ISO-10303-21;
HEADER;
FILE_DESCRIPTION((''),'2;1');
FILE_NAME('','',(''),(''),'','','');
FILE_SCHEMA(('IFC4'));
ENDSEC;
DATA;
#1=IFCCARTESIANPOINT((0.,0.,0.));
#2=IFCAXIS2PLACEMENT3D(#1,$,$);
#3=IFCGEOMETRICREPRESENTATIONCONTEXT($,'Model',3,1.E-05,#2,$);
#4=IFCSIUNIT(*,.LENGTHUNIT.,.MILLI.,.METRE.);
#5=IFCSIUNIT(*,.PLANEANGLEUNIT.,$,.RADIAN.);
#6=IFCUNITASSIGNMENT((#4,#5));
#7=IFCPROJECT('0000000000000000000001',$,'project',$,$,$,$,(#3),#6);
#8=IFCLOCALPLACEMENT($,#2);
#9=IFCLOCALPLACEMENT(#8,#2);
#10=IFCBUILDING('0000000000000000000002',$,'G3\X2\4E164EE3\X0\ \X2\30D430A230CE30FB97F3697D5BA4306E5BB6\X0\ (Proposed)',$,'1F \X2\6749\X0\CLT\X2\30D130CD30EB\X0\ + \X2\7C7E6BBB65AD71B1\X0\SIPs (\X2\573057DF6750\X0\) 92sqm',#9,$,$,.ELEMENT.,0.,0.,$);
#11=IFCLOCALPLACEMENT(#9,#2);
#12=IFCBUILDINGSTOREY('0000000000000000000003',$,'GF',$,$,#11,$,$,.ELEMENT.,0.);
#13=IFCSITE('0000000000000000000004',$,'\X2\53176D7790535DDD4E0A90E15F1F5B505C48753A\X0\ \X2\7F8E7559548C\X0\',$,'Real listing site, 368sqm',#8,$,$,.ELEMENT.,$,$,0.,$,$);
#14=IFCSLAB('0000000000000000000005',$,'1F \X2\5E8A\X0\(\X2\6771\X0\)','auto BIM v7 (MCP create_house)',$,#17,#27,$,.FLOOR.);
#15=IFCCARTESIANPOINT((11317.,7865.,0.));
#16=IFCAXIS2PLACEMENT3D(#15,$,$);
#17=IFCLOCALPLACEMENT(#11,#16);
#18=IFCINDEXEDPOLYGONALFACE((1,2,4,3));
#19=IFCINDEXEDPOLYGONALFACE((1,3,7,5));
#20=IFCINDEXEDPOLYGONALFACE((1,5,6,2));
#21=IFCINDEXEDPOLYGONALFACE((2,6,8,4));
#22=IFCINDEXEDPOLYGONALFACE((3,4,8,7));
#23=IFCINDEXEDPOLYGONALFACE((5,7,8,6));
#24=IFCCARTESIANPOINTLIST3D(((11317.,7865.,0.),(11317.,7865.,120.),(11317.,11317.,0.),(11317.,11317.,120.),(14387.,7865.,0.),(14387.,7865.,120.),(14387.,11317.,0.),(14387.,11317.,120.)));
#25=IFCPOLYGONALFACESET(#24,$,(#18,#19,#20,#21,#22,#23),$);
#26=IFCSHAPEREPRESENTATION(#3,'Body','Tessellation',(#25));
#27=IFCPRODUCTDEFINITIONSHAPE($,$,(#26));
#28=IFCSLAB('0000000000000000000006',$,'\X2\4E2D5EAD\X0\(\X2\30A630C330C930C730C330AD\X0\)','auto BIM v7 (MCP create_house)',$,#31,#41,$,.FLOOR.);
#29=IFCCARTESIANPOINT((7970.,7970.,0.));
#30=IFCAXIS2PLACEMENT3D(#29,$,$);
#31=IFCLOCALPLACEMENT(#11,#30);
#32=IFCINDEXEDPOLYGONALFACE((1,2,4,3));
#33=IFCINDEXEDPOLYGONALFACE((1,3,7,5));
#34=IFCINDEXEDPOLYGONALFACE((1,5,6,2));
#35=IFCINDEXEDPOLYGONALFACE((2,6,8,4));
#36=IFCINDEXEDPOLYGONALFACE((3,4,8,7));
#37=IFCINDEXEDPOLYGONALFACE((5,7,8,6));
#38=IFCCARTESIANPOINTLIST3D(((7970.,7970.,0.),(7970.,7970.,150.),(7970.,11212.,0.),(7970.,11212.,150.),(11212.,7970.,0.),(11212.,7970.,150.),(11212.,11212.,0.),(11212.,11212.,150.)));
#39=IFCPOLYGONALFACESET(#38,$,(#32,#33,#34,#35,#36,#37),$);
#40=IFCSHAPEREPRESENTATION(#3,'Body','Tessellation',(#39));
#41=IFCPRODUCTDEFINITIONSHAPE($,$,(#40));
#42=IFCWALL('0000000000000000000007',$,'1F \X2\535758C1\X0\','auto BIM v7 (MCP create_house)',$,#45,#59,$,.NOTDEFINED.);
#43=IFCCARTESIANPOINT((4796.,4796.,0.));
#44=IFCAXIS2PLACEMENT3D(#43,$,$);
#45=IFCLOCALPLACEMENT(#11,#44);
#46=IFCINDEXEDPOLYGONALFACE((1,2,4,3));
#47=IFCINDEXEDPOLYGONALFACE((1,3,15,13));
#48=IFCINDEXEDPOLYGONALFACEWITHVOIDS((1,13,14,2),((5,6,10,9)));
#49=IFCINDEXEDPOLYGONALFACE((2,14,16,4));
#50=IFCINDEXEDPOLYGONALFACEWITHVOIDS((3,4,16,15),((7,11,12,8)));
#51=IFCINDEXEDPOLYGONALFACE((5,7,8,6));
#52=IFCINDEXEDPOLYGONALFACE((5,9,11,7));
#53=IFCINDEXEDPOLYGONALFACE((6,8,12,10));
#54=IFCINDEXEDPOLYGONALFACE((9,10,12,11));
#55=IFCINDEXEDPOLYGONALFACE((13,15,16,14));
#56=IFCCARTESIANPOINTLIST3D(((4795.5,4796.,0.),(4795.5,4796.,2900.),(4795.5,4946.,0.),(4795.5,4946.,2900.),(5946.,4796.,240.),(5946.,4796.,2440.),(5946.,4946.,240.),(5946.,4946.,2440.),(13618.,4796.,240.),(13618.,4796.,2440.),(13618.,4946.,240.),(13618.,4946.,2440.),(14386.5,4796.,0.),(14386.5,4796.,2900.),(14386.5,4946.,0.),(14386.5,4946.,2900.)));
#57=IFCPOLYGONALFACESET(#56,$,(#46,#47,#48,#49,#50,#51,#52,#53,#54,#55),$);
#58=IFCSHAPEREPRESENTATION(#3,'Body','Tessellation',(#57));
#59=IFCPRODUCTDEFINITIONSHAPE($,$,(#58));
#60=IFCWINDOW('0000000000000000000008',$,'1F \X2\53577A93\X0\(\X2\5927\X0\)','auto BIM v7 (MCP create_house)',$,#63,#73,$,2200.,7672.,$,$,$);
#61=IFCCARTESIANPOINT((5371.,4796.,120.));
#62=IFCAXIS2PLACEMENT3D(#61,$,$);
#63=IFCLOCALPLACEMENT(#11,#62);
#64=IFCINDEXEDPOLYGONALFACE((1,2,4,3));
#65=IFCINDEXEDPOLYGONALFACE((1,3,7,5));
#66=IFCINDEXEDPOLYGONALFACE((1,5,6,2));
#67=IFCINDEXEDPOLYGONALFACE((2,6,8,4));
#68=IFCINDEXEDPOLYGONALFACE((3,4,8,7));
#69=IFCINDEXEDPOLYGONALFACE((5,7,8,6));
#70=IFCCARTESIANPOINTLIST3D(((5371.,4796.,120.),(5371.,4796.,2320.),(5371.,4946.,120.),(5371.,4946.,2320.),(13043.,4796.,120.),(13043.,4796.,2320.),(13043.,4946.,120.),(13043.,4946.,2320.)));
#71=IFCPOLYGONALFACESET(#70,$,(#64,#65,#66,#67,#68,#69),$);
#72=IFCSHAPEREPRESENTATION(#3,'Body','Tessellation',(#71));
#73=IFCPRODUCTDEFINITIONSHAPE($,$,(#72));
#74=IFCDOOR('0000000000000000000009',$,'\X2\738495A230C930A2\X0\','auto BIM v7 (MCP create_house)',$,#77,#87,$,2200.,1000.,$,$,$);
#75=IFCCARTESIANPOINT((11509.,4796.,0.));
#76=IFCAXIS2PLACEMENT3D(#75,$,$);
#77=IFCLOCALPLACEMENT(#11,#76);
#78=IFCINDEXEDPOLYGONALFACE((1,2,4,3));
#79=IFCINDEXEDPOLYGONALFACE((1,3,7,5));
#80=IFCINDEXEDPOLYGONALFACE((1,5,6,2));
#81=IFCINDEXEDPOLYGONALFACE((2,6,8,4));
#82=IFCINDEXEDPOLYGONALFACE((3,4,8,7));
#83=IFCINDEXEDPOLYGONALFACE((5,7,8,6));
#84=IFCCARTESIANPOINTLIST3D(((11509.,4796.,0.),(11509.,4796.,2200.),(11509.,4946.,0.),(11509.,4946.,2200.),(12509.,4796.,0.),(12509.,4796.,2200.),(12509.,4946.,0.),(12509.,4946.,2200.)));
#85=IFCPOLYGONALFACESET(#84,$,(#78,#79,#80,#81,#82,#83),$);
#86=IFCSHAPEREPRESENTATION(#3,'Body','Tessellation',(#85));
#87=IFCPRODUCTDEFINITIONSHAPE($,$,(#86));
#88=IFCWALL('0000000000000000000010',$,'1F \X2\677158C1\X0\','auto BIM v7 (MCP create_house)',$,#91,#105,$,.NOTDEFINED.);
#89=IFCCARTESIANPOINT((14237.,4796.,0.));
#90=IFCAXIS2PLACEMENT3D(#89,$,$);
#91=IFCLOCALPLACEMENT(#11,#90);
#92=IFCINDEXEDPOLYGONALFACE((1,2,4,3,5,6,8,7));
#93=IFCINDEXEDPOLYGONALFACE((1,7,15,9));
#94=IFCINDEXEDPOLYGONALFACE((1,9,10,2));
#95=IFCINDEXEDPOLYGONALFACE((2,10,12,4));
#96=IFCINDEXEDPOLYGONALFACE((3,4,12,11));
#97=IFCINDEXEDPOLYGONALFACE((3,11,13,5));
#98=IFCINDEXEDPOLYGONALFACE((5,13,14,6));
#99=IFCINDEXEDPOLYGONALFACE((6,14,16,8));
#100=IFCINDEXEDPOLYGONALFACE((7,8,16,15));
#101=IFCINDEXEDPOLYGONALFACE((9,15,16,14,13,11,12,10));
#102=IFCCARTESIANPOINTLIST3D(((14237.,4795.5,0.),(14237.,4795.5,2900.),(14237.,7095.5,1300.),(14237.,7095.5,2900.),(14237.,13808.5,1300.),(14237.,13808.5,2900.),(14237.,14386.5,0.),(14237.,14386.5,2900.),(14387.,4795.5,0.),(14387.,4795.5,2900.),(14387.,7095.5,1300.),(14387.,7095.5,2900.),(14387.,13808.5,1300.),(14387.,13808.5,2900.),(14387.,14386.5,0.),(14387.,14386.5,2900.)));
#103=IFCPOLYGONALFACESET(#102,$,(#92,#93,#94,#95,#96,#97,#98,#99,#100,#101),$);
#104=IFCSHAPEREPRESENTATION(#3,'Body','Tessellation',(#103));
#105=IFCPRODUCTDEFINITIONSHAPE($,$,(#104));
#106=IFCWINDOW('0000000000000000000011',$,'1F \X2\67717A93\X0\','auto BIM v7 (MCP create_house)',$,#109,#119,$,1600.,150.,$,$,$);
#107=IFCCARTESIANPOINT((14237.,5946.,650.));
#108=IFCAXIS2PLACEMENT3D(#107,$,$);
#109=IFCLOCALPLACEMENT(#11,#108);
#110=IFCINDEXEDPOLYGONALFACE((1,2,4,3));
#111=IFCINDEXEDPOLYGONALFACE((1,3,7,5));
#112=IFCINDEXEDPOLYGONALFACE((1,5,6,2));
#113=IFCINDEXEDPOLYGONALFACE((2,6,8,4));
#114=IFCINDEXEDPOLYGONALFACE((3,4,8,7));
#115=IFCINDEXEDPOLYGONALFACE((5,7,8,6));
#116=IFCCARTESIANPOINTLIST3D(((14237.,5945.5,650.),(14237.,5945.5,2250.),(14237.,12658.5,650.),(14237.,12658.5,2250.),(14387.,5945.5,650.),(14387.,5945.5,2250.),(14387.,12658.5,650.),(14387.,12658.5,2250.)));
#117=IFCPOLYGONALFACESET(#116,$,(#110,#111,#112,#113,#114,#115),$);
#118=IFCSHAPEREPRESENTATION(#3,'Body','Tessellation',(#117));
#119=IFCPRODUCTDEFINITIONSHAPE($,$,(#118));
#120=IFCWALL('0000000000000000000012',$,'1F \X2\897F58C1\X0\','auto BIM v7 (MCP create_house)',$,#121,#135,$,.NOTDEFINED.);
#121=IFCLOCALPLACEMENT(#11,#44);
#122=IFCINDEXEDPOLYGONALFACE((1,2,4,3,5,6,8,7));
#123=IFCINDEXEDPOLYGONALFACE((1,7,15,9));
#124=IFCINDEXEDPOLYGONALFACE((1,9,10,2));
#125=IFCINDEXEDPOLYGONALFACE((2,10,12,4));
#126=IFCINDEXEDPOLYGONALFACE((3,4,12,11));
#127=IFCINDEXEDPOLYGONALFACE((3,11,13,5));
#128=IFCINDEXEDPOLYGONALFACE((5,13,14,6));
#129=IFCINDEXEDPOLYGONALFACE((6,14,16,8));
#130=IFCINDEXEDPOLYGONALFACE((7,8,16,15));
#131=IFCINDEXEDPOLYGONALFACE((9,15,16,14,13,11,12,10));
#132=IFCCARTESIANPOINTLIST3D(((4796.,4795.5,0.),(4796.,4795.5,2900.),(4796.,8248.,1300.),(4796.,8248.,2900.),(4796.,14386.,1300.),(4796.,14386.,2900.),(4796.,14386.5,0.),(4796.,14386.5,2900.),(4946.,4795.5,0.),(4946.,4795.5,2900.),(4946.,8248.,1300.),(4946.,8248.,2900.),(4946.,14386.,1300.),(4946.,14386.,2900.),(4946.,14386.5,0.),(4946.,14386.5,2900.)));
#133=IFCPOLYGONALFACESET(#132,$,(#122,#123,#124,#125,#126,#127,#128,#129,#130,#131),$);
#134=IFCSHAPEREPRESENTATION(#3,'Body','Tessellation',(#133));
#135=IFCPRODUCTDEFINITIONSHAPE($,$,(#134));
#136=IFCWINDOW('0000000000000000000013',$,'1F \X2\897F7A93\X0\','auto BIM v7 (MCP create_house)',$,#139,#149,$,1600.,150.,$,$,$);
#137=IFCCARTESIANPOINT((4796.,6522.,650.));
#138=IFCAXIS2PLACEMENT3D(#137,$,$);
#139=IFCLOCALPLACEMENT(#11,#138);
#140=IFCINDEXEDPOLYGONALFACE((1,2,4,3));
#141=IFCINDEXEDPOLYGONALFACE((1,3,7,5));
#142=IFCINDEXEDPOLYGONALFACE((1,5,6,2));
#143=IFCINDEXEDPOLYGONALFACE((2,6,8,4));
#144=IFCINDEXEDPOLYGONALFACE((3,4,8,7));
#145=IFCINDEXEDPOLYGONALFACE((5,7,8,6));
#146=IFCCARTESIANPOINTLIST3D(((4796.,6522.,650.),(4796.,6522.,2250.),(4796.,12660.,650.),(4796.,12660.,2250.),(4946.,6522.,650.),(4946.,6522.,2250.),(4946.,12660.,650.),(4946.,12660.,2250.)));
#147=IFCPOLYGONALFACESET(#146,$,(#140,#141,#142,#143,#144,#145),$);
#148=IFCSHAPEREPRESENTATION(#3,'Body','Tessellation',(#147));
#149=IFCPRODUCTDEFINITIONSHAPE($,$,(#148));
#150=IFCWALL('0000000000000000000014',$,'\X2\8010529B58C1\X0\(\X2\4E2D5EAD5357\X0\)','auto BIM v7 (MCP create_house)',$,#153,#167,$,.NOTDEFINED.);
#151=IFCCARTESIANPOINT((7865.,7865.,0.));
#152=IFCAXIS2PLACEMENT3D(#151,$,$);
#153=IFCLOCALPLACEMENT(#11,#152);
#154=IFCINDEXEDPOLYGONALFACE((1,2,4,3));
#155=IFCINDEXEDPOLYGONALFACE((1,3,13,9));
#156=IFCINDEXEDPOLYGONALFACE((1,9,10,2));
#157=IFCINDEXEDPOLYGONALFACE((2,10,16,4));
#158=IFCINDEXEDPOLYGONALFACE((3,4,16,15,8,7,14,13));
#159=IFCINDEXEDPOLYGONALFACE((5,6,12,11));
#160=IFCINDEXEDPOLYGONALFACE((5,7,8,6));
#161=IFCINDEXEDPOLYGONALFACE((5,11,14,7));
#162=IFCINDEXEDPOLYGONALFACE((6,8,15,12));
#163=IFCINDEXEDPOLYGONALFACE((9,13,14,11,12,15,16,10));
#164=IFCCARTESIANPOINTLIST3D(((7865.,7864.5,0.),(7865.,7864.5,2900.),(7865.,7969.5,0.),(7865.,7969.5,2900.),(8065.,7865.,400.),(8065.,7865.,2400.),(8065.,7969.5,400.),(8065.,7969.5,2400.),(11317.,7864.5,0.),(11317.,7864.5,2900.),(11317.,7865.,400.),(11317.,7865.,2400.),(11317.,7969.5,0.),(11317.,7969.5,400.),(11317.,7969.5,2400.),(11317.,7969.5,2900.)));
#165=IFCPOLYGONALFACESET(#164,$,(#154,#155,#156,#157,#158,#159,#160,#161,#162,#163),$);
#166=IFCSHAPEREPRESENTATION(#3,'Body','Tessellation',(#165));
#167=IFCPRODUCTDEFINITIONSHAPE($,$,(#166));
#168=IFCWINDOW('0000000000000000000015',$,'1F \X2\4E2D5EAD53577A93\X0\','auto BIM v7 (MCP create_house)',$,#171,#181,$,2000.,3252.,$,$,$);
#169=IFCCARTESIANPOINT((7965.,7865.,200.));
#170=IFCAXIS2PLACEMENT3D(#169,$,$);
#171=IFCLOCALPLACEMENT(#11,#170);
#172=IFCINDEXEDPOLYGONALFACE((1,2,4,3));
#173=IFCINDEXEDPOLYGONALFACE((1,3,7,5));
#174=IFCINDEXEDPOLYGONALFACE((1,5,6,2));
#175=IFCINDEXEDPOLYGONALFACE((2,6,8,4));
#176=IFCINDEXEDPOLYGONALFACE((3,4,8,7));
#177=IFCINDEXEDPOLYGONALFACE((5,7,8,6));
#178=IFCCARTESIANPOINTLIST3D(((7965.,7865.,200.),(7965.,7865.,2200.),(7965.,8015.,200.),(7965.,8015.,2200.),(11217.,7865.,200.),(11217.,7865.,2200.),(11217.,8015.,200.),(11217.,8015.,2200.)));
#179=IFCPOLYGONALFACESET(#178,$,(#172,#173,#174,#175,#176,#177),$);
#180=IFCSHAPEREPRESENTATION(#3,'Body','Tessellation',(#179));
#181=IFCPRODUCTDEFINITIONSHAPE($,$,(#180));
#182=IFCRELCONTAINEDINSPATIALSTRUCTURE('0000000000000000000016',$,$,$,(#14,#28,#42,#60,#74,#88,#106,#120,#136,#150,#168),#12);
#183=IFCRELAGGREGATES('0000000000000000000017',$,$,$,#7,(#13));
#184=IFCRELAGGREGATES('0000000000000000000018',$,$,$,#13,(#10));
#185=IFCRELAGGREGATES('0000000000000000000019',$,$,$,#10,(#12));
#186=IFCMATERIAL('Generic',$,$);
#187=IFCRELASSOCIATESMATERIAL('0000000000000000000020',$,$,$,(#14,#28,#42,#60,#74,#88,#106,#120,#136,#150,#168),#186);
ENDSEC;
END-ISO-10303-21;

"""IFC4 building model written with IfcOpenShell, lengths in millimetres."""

from ifc_helpers import new_model, si_unit, frame, frame_2d, origin, place, context, project, spatial, rectangle, extrude, material, element, fill, save


model = new_model("IFC4")

# Units and contexts
model_context = context("Model", 3, precision=1e-05, world=origin())
ifc_project = project(units=[si_unit("LENGTHUNIT", "METRE", prefix="MILLI"), si_unit("PLANEANGLEUNIT", "RADIAN")], contexts=[model_context])

# Site, building, storey
site_placement = place(None, origin())
site = spatial("IfcSite", under=ifc_project, at=site_placement, Name="北海道川上郡弟子屈町 美留和", ObjectType="Real listing site, 368sqm", CompositionType="ELEMENT", RefElevation=0.0)
building_placement = place(site_placement, origin())
building = spatial("IfcBuilding", under=site, at=building_placement, Name="G3世代 ピアノ・音楽室の家 (Proposed)", ObjectType="1F 杉CLTパネル + 籾殻断熱SIPs (地域材) 92sqm", CompositionType="ELEMENT", ElevationOfRefHeight=0.0, ElevationOfTerrain=0.0)
storey_placement = place(building_placement, origin())
storey = spatial("IfcBuildingStorey", under=building, at=storey_placement, Name="GF", CompositionType="ELEMENT", Elevation=0.0)

# Slabs
ifc_material = material(Name="Generic")
slab_1_placement = place(storey_placement, frame((11317.0, 7865.0, 0.0)))
element("IfcSlab", 1, at=slab_1_placement, inside=storey, material=ifc_material, Name="1F 床(東)", Description="auto BIM v7 (MCP create_house)", PredefinedType="FLOOR", context=model_context, shape_type="SweptSolid", body=[
    extrude(rectangle(XDim=3070.0, YDim=3452.0, at=frame_2d((1535.0, 1726.0))), frame((11317.0, 7865.0, 0.0)), (0.0, 0.0, 1.0), 120.0),
])
slab_2_placement = place(storey_placement, frame((7970.0, 7970.0, 0.0)))
element("IfcSlab", 2, at=slab_2_placement, inside=storey, material=ifc_material, Name="中庭(ウッドデッキ)", Description="auto BIM v7 (MCP create_house)", PredefinedType="FLOOR", context=model_context, shape_type="SweptSolid", body=[
    extrude(rectangle(XDim=3242.0, YDim=3242.0, at=frame_2d((1621.0, 1621.0))), frame((7970.0, 7970.0, 0.0)), (0.0, 0.0, 1.0), 150.0),
])

# Wall, openings, window, door
wall_1_placement = place(storey_placement, frame((4796.0, 4796.0, 0.0)))
wall_1 = element("IfcWall", 3, at=wall_1_placement, inside=storey, material=ifc_material, Name="1F 南壁", Description="auto BIM v7 (MCP create_house)", PredefinedType="NOTDEFINED", context=model_context, shape_type="SweptSolid", body=[
    extrude(rectangle(XDim=9591.0, YDim=150.0, at=frame_2d((4795.0, 75.0))), frame((4796.0, 4796.0, 0.0)), (0.0, 0.0, 1.0), 2900.0),
])
opening_1_placement = place(storey_placement, frame((5371.0, 4796.0, 120.0)))
opening_1 = element("IfcOpeningElement", 4, at=opening_1_placement, cuts=wall_1, PredefinedType="NOTDEFINED", context=model_context, shape_type="SweptSolid", body=[
    extrude(rectangle(XDim=7672.0, YDim=150.0, at=frame_2d((3836.0, 75.0))), frame((5371.0, 4796.0, 120.0)), (0.0, 0.0, 1.0), 2200.0),
])
opening_2_placement = place(storey_placement, frame((11509.0, 4796.0, 0.0)))
opening_2 = element("IfcOpeningElement", 5, at=opening_2_placement, cuts=wall_1, PredefinedType="NOTDEFINED", context=model_context, shape_type="SweptSolid", body=[
    extrude(rectangle(XDim=1000.0, YDim=150.0, at=frame_2d((500.0, 75.0))), frame((11509.0, 4796.0, 0.0)), (0.0, 0.0, 1.0), 2200.0),
])
window_1_placement = place(storey_placement, frame((5371.0, 4796.0, 120.0)))
window_1 = element("IfcWindow", 6, at=window_1_placement, inside=storey, material=ifc_material, Name="1F 南窓(大)", Description="auto BIM v7 (MCP create_house)", OverallHeight=2200.0, OverallWidth=7672.0, context=model_context, shape_type="SweptSolid", body=[
    extrude(rectangle(XDim=7672.0, YDim=150.0, at=frame_2d((3836.0, 75.0))), frame((5371.0, 4796.0, 120.0)), (0.0, 0.0, 1.0), 2200.0),
])
fill(opening_1, window_1)
door_placement = place(storey_placement, frame((11509.0, 4796.0, 0.0)))
door = element("IfcDoor", 7, at=door_placement, inside=storey, material=ifc_material, Name="玄関ドア", Description="auto BIM v7 (MCP create_house)", OverallHeight=2200.0, OverallWidth=1000.0, context=model_context, shape_type="SweptSolid", body=[
    extrude(rectangle(XDim=1000.0, YDim=150.0, at=frame_2d((500.0, 75.0))), frame((11509.0, 4796.0, 0.0)), (0.0, 0.0, 1.0), 2200.0),
])
fill(opening_2, door)

# Walls, openings, windows
wall_2_placement = place(storey_placement, frame((14237.0, 4796.0, 0.0)))
wall_2 = element("IfcWall", 8, at=wall_2_placement, inside=storey, material=ifc_material, Name="1F 東壁", Description="auto BIM v7 (MCP create_house)", PredefinedType="NOTDEFINED", context=model_context, shape_type="SweptSolid", body=[
    extrude(rectangle(XDim=150.0, YDim=9591.0, at=frame_2d((75.0, 4795.0))), frame((14237.0, 4796.0, 0.0)), (0.0, 0.0, 1.0), 2900.0),
])
opening_3_placement = place(storey_placement, frame((14237.0, 5946.0, 650.0)))
opening_3 = element("IfcOpeningElement", 9, at=opening_3_placement, cuts=wall_2, PredefinedType="NOTDEFINED", context=model_context, shape_type="SweptSolid", body=[
    extrude(rectangle(XDim=150.0, YDim=6713.0, at=frame_2d((75.0, 3356.0))), frame((14237.0, 5946.0, 650.0)), (0.0, 0.0, 1.0), 1600.0),
])
window_2_placement = place(storey_placement, frame((14237.0, 5946.0, 650.0)))
window_2 = element("IfcWindow", 10, at=window_2_placement, inside=storey, material=ifc_material, Name="1F 東窓", Description="auto BIM v7 (MCP create_house)", OverallHeight=1600.0, OverallWidth=150.0, context=model_context, shape_type="SweptSolid", body=[
    extrude(rectangle(XDim=150.0, YDim=6713.0, at=frame_2d((75.0, 3356.0))), frame((14237.0, 5946.0, 650.0)), (0.0, 0.0, 1.0), 1600.0),
])
fill(opening_3, window_2)
wall_3_placement = place(storey_placement, frame((4796.0, 4796.0, 0.0)))
wall_3 = element("IfcWall", 11, at=wall_3_placement, inside=storey, material=ifc_material, Name="1F 西壁", Description="auto BIM v7 (MCP create_house)", PredefinedType="NOTDEFINED", context=model_context, shape_type="SweptSolid", body=[
    extrude(rectangle(XDim=150.0, YDim=9591.0, at=frame_2d((75.0, 4795.0))), frame((4796.0, 4796.0, 0.0)), (0.0, 0.0, 1.0), 2900.0),
])
opening_4_placement = place(storey_placement, frame((4796.0, 6522.0, 650.0)))
opening_4 = element("IfcOpeningElement", 12, at=opening_4_placement, cuts=wall_3, PredefinedType="NOTDEFINED", context=model_context, shape_type="SweptSolid", body=[
    extrude(rectangle(XDim=150.0, YDim=6138.0, at=frame_2d((75.0, 3069.0))), frame((4796.0, 6522.0, 650.0)), (0.0, 0.0, 1.0), 1600.0),
])
window_3_placement = place(storey_placement, frame((4796.0, 6522.0, 650.0)))
window_3 = element("IfcWindow", 13, at=window_3_placement, inside=storey, material=ifc_material, Name="1F 西窓", Description="auto BIM v7 (MCP create_house)", OverallHeight=1600.0, OverallWidth=150.0, context=model_context, shape_type="SweptSolid", body=[
    extrude(rectangle(XDim=150.0, YDim=6138.0, at=frame_2d((75.0, 3069.0))), frame((4796.0, 6522.0, 650.0)), (0.0, 0.0, 1.0), 1600.0),
])
fill(opening_4, window_3)
wall_4_placement = place(storey_placement, frame((7865.0, 7865.0, 0.0)))
wall_4 = element("IfcWall", 14, at=wall_4_placement, inside=storey, material=ifc_material, Name="耐力壁(中庭南)", Description="auto BIM v7 (MCP create_house)", PredefinedType="NOTDEFINED", context=model_context, shape_type="SweptSolid", body=[
    extrude(rectangle(XDim=3452.0, YDim=105.0, at=frame_2d((1726.0, 52.0))), frame((7865.0, 7865.0, 0.0)), (0.0, 0.0, 1.0), 2900.0),
])
opening_5_placement = place(storey_placement, frame((7965.0, 7865.0, 200.0)))
opening_5 = element("IfcOpeningElement", 15, at=opening_5_placement, cuts=wall_4, PredefinedType="NOTDEFINED", context=model_context, shape_type="SweptSolid", body=[
    extrude(rectangle(XDim=3252.0, YDim=150.0, at=frame_2d((1626.0, 75.0))), frame((7965.0, 7865.0, 200.0)), (0.0, 0.0, 1.0), 2000.0),
])
window_4_placement = place(storey_placement, frame((7965.0, 7865.0, 200.0)))
window_4 = element("IfcWindow", 16, at=window_4_placement, inside=storey, material=ifc_material, Name="1F 中庭南窓", Description="auto BIM v7 (MCP create_house)", OverallHeight=2000.0, OverallWidth=3252.0, context=model_context, shape_type="SweptSolid", body=[
    extrude(rectangle(XDim=3252.0, YDim=150.0, at=frame_2d((1626.0, 75.0))), frame((7965.0, 7865.0, 200.0)), (0.0, 0.0, 1.0), 2000.0),
])
fill(opening_5, window_4)

save(model, "model.ifc")
